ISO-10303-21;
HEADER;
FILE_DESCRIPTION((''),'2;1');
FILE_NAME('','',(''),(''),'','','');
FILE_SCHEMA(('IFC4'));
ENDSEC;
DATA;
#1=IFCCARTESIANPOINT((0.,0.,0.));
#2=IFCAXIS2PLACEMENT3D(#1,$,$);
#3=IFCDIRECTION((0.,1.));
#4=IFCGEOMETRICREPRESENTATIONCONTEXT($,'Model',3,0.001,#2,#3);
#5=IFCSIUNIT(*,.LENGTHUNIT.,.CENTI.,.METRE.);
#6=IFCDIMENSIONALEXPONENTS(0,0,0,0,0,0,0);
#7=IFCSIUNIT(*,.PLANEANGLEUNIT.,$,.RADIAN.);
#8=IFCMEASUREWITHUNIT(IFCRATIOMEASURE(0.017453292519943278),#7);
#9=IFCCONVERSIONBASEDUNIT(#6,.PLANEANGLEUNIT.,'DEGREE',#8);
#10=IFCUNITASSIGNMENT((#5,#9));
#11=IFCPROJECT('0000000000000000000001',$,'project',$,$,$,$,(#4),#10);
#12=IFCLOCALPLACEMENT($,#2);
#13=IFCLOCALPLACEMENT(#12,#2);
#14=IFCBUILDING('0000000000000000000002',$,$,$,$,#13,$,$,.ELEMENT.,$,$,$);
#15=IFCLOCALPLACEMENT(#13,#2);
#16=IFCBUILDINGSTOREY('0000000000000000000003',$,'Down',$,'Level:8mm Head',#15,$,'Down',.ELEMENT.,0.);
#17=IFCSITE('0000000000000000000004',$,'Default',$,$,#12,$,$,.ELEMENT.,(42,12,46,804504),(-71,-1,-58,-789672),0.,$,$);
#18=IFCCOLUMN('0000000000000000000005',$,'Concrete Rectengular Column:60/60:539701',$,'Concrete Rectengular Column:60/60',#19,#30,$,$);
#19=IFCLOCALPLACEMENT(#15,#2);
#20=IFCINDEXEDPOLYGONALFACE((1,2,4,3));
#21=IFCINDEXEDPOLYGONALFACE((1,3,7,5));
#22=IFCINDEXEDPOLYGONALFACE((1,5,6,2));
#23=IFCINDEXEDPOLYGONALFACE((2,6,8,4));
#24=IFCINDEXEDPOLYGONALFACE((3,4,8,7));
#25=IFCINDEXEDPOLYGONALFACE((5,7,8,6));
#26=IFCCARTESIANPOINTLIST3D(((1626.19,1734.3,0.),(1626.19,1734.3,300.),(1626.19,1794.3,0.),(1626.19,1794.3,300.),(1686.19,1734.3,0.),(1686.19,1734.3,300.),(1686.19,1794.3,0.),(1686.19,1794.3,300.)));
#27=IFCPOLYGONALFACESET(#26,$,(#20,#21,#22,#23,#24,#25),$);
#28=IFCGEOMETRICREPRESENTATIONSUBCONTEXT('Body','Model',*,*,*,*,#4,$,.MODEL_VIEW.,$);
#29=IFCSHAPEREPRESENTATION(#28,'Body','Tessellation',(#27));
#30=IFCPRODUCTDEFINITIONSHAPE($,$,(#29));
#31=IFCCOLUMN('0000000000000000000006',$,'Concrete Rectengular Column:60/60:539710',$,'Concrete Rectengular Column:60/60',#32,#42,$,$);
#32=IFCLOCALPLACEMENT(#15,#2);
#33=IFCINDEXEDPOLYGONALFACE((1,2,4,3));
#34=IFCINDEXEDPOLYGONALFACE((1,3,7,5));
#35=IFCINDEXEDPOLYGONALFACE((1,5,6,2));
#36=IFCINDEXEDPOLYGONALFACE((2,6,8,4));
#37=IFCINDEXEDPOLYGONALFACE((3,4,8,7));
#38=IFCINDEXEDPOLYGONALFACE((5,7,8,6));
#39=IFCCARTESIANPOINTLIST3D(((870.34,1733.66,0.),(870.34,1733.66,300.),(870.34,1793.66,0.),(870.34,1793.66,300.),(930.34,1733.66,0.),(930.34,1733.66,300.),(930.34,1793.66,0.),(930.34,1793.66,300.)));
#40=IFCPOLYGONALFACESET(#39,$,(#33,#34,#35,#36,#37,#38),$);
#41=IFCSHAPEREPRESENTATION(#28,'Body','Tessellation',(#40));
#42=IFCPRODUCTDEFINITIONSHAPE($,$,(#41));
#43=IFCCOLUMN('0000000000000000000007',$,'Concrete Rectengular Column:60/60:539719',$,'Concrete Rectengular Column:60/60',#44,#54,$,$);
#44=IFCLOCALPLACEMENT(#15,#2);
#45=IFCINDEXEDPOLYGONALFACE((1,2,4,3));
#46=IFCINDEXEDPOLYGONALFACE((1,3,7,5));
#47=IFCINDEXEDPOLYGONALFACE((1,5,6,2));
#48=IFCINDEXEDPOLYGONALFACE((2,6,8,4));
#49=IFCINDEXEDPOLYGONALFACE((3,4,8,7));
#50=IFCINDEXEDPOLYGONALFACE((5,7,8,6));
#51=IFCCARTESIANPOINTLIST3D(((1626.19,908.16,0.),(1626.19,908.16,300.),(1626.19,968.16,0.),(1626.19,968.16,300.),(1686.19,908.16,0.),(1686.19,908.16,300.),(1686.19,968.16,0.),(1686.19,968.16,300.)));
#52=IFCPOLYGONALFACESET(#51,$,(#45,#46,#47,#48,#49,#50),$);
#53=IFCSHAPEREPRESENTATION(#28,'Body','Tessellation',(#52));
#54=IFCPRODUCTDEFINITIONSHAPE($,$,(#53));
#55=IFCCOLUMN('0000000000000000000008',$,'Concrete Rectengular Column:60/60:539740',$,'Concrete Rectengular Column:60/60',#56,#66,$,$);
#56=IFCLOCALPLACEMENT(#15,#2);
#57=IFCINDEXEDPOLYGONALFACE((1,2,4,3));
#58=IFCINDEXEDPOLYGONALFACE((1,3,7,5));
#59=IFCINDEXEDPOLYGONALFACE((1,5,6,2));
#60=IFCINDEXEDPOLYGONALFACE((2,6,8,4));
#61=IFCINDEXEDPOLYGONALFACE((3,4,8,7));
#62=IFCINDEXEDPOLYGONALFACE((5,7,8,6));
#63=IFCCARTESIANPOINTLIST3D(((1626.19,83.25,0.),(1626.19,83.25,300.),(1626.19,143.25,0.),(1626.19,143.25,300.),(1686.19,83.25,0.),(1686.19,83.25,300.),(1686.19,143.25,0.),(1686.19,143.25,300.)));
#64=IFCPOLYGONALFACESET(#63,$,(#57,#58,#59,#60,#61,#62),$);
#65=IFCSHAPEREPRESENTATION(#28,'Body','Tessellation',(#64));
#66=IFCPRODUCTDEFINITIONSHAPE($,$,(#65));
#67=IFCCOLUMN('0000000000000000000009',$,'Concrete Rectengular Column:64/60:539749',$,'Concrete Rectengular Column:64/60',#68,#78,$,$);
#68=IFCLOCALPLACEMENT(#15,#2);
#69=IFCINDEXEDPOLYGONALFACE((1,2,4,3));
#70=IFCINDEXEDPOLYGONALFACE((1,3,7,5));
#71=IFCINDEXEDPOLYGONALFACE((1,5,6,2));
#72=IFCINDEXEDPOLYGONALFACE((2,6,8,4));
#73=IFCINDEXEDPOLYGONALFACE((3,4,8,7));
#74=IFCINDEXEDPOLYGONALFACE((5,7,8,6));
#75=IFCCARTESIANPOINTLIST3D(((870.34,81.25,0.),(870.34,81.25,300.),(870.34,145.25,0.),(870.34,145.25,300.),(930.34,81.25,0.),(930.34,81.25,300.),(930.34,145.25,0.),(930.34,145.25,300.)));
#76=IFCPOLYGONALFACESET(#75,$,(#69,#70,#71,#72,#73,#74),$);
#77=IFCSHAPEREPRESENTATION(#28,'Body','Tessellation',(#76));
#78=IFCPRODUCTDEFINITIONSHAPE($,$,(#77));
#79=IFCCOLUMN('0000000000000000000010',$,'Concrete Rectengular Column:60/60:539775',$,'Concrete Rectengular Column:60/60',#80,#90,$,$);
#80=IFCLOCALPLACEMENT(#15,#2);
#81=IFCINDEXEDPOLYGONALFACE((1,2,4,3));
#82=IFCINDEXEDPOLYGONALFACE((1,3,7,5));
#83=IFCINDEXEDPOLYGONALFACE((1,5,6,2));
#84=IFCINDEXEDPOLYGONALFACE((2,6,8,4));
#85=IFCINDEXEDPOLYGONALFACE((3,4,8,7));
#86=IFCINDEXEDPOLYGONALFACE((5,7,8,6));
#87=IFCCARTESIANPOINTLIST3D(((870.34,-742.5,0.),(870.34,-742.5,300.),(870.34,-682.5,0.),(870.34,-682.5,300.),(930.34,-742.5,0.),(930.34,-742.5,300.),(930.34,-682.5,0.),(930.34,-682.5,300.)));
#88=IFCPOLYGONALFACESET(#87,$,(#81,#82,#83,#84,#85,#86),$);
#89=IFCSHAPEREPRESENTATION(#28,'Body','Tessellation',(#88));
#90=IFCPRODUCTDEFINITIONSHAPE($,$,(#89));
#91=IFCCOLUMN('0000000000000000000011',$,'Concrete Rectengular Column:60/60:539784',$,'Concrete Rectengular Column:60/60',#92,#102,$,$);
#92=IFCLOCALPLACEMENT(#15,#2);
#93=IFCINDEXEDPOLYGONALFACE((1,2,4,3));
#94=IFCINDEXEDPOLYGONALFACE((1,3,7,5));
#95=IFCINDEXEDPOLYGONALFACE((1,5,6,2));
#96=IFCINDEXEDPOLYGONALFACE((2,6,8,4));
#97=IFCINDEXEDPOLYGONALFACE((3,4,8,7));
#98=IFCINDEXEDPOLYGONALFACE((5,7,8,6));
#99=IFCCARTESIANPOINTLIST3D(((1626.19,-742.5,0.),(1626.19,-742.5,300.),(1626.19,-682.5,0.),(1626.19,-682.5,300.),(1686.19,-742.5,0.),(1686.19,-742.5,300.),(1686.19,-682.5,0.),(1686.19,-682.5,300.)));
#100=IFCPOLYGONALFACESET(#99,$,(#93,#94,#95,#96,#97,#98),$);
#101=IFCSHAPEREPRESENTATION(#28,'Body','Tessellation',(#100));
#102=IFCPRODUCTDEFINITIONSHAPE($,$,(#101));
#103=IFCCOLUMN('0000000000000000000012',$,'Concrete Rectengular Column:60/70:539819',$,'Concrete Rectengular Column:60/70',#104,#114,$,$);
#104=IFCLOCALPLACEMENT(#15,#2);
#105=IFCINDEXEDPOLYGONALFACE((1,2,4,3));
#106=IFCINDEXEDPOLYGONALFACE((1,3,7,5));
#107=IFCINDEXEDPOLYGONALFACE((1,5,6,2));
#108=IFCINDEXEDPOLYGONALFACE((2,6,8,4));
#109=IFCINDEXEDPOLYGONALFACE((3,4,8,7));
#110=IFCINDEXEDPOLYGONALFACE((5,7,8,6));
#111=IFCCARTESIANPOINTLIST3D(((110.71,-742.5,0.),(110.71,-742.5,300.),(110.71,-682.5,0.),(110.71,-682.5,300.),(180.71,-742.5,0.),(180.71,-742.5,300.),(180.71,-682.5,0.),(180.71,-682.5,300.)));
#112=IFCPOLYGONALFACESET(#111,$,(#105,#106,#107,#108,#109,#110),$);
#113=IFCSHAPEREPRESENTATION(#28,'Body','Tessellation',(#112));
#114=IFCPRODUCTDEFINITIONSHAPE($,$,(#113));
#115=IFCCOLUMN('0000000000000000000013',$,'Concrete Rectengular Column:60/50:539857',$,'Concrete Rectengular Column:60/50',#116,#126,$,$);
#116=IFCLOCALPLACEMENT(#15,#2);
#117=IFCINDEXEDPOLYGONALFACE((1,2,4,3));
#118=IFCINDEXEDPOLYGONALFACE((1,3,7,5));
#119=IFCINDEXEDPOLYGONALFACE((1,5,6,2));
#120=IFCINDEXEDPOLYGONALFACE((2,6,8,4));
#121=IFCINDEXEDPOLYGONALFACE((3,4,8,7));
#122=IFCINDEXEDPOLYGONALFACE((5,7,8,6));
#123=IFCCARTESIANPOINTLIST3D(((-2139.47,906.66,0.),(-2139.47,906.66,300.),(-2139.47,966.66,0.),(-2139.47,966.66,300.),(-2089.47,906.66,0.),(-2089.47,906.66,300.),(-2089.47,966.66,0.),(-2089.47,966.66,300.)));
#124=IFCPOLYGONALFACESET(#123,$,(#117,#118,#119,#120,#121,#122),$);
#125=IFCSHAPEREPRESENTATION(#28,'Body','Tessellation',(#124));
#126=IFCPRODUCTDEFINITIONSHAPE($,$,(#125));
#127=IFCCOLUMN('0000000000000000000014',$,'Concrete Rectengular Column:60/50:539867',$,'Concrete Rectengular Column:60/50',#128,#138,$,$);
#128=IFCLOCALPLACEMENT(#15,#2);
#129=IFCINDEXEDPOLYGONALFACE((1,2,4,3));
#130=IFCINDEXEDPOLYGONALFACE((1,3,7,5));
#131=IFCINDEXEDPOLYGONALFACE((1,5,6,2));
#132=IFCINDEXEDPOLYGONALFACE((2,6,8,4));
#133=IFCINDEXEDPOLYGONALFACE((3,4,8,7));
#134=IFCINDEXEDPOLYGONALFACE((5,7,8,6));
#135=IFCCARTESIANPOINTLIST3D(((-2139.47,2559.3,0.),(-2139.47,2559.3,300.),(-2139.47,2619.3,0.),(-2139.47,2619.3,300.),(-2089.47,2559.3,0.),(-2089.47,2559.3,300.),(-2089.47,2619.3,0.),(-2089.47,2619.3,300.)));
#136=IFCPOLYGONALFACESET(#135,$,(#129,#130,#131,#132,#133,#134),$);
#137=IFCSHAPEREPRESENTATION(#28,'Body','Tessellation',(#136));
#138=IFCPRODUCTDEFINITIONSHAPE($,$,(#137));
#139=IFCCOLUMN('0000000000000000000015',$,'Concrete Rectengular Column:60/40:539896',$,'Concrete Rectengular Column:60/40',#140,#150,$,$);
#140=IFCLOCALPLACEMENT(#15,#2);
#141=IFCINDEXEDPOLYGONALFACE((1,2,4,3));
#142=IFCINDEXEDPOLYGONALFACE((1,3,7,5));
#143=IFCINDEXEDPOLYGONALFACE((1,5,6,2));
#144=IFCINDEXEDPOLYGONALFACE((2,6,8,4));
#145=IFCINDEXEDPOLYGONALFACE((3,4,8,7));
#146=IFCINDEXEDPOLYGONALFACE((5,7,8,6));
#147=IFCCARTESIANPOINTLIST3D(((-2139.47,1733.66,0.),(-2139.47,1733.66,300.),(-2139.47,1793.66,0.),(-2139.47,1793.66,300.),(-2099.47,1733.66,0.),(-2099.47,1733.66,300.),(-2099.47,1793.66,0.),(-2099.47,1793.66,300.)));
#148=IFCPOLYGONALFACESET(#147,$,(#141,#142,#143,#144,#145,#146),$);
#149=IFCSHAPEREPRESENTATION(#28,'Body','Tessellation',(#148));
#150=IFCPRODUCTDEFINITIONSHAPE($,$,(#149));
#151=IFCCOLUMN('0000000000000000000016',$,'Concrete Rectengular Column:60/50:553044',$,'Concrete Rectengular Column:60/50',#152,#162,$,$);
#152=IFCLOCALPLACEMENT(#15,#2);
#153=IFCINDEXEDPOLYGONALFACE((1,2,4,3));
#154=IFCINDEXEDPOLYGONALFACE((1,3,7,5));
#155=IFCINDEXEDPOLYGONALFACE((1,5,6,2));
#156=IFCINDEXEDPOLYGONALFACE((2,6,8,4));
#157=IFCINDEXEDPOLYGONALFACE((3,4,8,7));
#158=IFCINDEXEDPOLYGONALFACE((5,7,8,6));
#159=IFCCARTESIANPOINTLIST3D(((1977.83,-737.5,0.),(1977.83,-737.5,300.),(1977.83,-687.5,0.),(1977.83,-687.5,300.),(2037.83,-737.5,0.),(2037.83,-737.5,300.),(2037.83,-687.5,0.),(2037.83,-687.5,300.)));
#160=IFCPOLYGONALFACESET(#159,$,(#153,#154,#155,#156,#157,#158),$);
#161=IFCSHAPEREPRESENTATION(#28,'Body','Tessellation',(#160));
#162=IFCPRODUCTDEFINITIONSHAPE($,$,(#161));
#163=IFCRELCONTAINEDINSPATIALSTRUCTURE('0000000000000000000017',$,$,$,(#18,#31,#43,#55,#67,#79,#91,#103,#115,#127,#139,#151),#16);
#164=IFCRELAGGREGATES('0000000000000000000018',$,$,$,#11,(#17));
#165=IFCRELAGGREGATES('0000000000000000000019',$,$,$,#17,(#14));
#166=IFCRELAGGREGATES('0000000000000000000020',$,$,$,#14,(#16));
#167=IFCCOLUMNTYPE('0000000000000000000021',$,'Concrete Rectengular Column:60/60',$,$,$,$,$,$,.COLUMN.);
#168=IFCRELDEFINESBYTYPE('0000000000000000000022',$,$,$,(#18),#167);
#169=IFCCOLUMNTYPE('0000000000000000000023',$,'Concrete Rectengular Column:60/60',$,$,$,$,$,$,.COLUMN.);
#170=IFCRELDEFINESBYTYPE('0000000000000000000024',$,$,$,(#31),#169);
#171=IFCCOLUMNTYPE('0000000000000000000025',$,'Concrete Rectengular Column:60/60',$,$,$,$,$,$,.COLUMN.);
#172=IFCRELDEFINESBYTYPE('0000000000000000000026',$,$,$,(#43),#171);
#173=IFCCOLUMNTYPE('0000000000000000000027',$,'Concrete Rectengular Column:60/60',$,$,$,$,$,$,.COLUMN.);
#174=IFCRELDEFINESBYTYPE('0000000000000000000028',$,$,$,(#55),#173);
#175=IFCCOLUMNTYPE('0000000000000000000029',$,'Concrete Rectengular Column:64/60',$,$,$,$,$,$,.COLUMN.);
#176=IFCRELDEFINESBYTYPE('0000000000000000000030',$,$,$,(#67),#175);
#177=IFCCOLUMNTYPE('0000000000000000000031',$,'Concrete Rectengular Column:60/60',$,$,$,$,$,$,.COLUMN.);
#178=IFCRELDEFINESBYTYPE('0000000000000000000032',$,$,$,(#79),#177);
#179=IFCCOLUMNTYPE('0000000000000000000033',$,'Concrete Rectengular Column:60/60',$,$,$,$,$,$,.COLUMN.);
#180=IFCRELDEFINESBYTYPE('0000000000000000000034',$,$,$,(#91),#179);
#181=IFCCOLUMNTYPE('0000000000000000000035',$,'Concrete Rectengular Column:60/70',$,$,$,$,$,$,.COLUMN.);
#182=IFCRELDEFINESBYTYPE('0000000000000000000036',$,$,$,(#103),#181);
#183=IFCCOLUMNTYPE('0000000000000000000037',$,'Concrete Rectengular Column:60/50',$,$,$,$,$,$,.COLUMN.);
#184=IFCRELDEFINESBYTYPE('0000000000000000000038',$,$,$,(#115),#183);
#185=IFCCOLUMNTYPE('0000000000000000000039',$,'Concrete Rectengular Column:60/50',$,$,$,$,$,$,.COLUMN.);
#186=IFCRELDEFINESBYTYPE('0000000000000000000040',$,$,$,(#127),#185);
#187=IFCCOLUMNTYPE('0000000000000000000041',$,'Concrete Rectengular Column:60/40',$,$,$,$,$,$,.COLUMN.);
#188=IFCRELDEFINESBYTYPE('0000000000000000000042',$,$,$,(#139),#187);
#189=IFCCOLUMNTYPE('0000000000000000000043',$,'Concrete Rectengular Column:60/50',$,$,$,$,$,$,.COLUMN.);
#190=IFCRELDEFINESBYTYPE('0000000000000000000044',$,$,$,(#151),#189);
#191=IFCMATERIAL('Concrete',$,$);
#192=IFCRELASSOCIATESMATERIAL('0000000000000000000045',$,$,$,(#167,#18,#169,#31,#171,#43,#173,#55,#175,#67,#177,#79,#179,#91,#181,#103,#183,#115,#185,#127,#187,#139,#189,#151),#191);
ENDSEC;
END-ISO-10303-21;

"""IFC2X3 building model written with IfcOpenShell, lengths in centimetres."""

from ifc_helpers import new_model, entity, si_unit, converted_unit, direction, frame, frame_2d, origin, origin_2d_with_axis, place, context, subcontext, project, spatial, rectangle, extrude, source, transform, mapped, material, type_object, type_shapes, element, save


model = new_model("IFC2X3")

# Units and contexts
model_context = context("Model", 3, precision=0.001, world=origin(), true_north=direction((0.0, 1.0)))
body_context = subcontext(model_context, "Body", "Model", "MODEL_VIEW")
ifc_project = project(units=[si_unit("LENGTHUNIT", "METRE", prefix="CENTI"), converted_unit("PLANEANGLEUNIT", "DEGREE", entity("IfcRatioMeasure", 0.017453292519943278), si_unit("PLANEANGLEUNIT", "RADIAN"), dimensions=[0, 0, 0, 0, 0, 0, 0])], contexts=[model_context])

# Site, building, storey
site_placement = place(None, origin())
site = spatial("IfcSite", under=ifc_project, at=site_placement, Name="Default", CompositionType="ELEMENT", RefLatitude=(42, 12, 46, 804504), RefLongitude=(-71, -1, -58, -789672), RefElevation=0.0)
building_placement = place(site_placement, origin())
building = spatial("IfcBuilding", under=site, at=building_placement, CompositionType="ELEMENT")
storey_placement = place(building_placement, origin())
storey = spatial("IfcBuildingStorey", under=building, at=storey_placement, Name="Down", ObjectType="Level:8mm Head", LongName="Down", CompositionType="ELEMENT", Elevation=0.0)

# Columns
ifc_material = material(Name="Concrete")
column_type_1 = type_object("IfcColumnType", Name="Concrete Rectengular Column:60/60", PredefinedType="COLUMN", material=ifc_material)
shared_shape_1 = source(origin(), body_context, "Body", "SweptSolid", [
    extrude(rectangle(XDim=60.0, YDim=60.0, at=frame_2d((0.0, 0.0), x_axis=(1.0, 0.0))), frame((1656.19, 1764.3, 0.0), z_axis=(0.0, 0.0, 1.0), x_axis=(0.0, -1.0, 0.0)), (0.0, 0.0, 1.0), 300.0),
])
type_shapes(column_type_1, [shared_shape_1])
column_1_placement = place(storey_placement, origin())
element("IfcColumn", 1, at=column_1_placement, inside=storey, type_object=column_type_1, material=ifc_material, Name="Concrete Rectengular Column:60/60:539701", ObjectType="Concrete Rectengular Column:60/60", context=body_context, shape_type="MappedRepresentation", body=[
    mapped(shared_shape_1, transform((0.0, 0.0, 0.0), scale=1.0)),
])
column_type_2 = type_object("IfcColumnType", Name="Concrete Rectengular Column:60/60", PredefinedType="COLUMN", material=ifc_material)
shared_shape_2 = source(origin(), body_context, "Body", "SweptSolid", [
    extrude(rectangle(XDim=60.0, YDim=60.0, at=frame_2d((0.0, 0.0), x_axis=(1.0, 0.0))), frame((900.34, 1763.66, 0.0), z_axis=(0.0, 0.0, 1.0), x_axis=(0.0, -1.0, 0.0)), (0.0, 0.0, 1.0), 300.0),
])
type_shapes(column_type_2, [shared_shape_2])
column_2_placement = place(storey_placement, origin())
element("IfcColumn", 2, at=column_2_placement, inside=storey, type_object=column_type_2, material=ifc_material, Name="Concrete Rectengular Column:60/60:539710", ObjectType="Concrete Rectengular Column:60/60", context=body_context, shape_type="MappedRepresentation", body=[
    mapped(shared_shape_2, transform((0.0, 0.0, 0.0), scale=1.0)),
])
column_type_3 = type_object("IfcColumnType", Name="Concrete Rectengular Column:60/60", PredefinedType="COLUMN", material=ifc_material)
shared_shape_3 = source(origin(), body_context, "Body", "SweptSolid", [
    extrude(rectangle(XDim=60.0, YDim=60.0, at=frame_2d((0.0, 0.0), x_axis=(1.0, 0.0))), frame((1656.19, 938.16, 0.0), z_axis=(0.0, 0.0, 1.0), x_axis=(0.0, -1.0, 0.0)), (0.0, 0.0, 1.0), 300.0),
])
type_shapes(column_type_3, [shared_shape_3])
column_3_placement = place(storey_placement, origin())
element("IfcColumn", 3, at=column_3_placement, inside=storey, type_object=column_type_3, material=ifc_material, Name="Concrete Rectengular Column:60/60:539719", ObjectType="Concrete Rectengular Column:60/60", context=body_context, shape_type="MappedRepresentation", body=[
    mapped(shared_shape_3, transform((0.0, 0.0, 0.0), scale=1.0)),
])
column_type_4 = type_object("IfcColumnType", Name="Concrete Rectengular Column:60/60", PredefinedType="COLUMN", material=ifc_material)
shared_shape_4 = source(origin(), body_context, "Body", "SweptSolid", [
    extrude(rectangle(XDim=60.0, YDim=60.0, at=frame_2d((0.0, 0.0), x_axis=(1.0, 0.0))), frame((1656.19, 113.25, 0.0), z_axis=(0.0, 0.0, 1.0), x_axis=(0.0, -1.0, 0.0)), (0.0, 0.0, 1.0), 300.0),
])
type_shapes(column_type_4, [shared_shape_4])
column_4_placement = place(storey_placement, origin())
element("IfcColumn", 4, at=column_4_placement, inside=storey, type_object=column_type_4, material=ifc_material, Name="Concrete Rectengular Column:60/60:539740", ObjectType="Concrete Rectengular Column:60/60", context=body_context, shape_type="MappedRepresentation", body=[
    mapped(shared_shape_4, transform((0.0, 0.0, 0.0), scale=1.0)),
])
column_type_5 = type_object("IfcColumnType", Name="Concrete Rectengular Column:64/60", PredefinedType="COLUMN", material=ifc_material)
shared_shape_5 = source(origin(), body_context, "Body", "SweptSolid", [
    extrude(rectangle(XDim=64.0, YDim=60.0, at=origin_2d_with_axis()), frame((900.34, 113.25, 0.0), z_axis=(0.0, 0.0, 1.0), x_axis=(0.0, -1.0, 0.0)), (0.0, 0.0, 1.0), 300.0),
])
type_shapes(column_type_5, [shared_shape_5])
column_5_placement = place(storey_placement, origin())
element("IfcColumn", 5, at=column_5_placement, inside=storey, type_object=column_type_5, material=ifc_material, Name="Concrete Rectengular Column:64/60:539749", ObjectType="Concrete Rectengular Column:64/60", context=body_context, shape_type="MappedRepresentation", body=[
    mapped(shared_shape_5, transform((0.0, 0.0, 0.0), scale=1.0)),
])
column_type_6 = type_object("IfcColumnType", Name="Concrete Rectengular Column:60/60", PredefinedType="COLUMN", material=ifc_material)
shared_shape_6 = source(origin(), body_context, "Body", "SweptSolid", [
    extrude(rectangle(XDim=60.0, YDim=60.0, at=origin_2d_with_axis()), frame((900.34, -712.5, 0.0), z_axis=(0.0, 0.0, 1.0), x_axis=(0.0, -1.0, 0.0)), (0.0, 0.0, 1.0), 300.0),
])
type_shapes(column_type_6, [shared_shape_6])
column_6_placement = place(storey_placement, origin())
element("IfcColumn", 6, at=column_6_placement, inside=storey, type_object=column_type_6, material=ifc_material, Name="Concrete Rectengular Column:60/60:539775", ObjectType="Concrete Rectengular Column:60/60", context=body_context, shape_type="MappedRepresentation", body=[
    mapped(shared_shape_6, transform((0.0, 0.0, 0.0), scale=1.0)),
])
column_type_7 = type_object("IfcColumnType", Name="Concrete Rectengular Column:60/60", PredefinedType="COLUMN", material=ifc_material)
shared_shape_7 = source(origin(), body_context, "Body", "SweptSolid", [
    extrude(rectangle(XDim=60.0, YDim=60.0, at=frame_2d((0.0, 0.0), x_axis=(1.0, 0.0))), frame((1656.19, -712.5, 0.0), z_axis=(0.0, 0.0, 1.0), x_axis=(0.0, -1.0, 0.0)), (0.0, 0.0, 1.0), 300.0),
])
type_shapes(column_type_7, [shared_shape_7])
column_7_placement = place(storey_placement, origin())
element("IfcColumn", 7, at=column_7_placement, inside=storey, type_object=column_type_7, material=ifc_material, Name="Concrete Rectengular Column:60/60:539784", ObjectType="Concrete Rectengular Column:60/60", context=body_context, shape_type="MappedRepresentation", body=[
    mapped(shared_shape_7, transform((0.0, 0.0, 0.0), scale=1.0)),
])
column_type_8 = type_object("IfcColumnType", Name="Concrete Rectengular Column:60/70", PredefinedType="COLUMN", material=ifc_material)
shared_shape_8 = source(origin(), body_context, "Body", "SweptSolid", [
    extrude(rectangle(XDim=60.0, YDim=70.0, at=frame_2d((0.0, 0.0), x_axis=(1.0, 0.0))), frame((145.71, -712.5, 0.0), z_axis=(0.0, 0.0, 1.0), x_axis=(0.0, -1.0, 0.0)), (0.0, 0.0, 1.0), 300.0),
])
type_shapes(column_type_8, [shared_shape_8])
column_8_placement = place(storey_placement, origin())
element("IfcColumn", 8, at=column_8_placement, inside=storey, type_object=column_type_8, material=ifc_material, Name="Concrete Rectengular Column:60/70:539819", ObjectType="Concrete Rectengular Column:60/70", context=body_context, shape_type="MappedRepresentation", body=[
    mapped(shared_shape_8, transform((0.0, 0.0, 0.0), scale=1.0)),
])
column_type_9 = type_object("IfcColumnType", Name="Concrete Rectengular Column:60/50", PredefinedType="COLUMN", material=ifc_material)
shared_shape_9 = source(origin(), body_context, "Body", "SweptSolid", [
    extrude(rectangle(XDim=60.0, YDim=50.0, at=origin_2d_with_axis()), frame((-2114.47, 936.66, 0.0), z_axis=(0.0, 0.0, 1.0), x_axis=(0.0, -1.0, 0.0)), (0.0, 0.0, 1.0), 300.0),
])
type_shapes(column_type_9, [shared_shape_9])
column_9_placement = place(storey_placement, origin())
element("IfcColumn", 9, at=column_9_placement, inside=storey, type_object=column_type_9, material=ifc_material, Name="Concrete Rectengular Column:60/50:539857", ObjectType="Concrete Rectengular Column:60/50", context=body_context, shape_type="MappedRepresentation", body=[
    mapped(shared_shape_9, transform((0.0, 0.0, 0.0), scale=1.0)),
])
column_type_10 = type_object("IfcColumnType", Name="Concrete Rectengular Column:60/50", PredefinedType="COLUMN", material=ifc_material)
shared_shape_10 = source(origin(), body_context, "Body", "SweptSolid", [
    extrude(rectangle(XDim=60.0, YDim=50.0, at=origin_2d_with_axis()), frame((-2114.47, 2589.3, 0.0), z_axis=(0.0, 0.0, 1.0), x_axis=(0.0, -1.0, 0.0)), (0.0, 0.0, 1.0), 300.0),
])
type_shapes(column_type_10, [shared_shape_10])
column_10_placement = place(storey_placement, origin())
element("IfcColumn", 10, at=column_10_placement, inside=storey, type_object=column_type_10, material=ifc_material, Name="Concrete Rectengular Column:60/50:539867", ObjectType="Concrete Rectengular Column:60/50", context=body_context, shape_type="MappedRepresentation", body=[
    mapped(shared_shape_10, transform((0.0, 0.0, 0.0), scale=1.0)),
])
column_type_11 = type_object("IfcColumnType", Name="Concrete Rectengular Column:60/40", PredefinedType="COLUMN", material=ifc_material)
shared_shape_11 = source(origin(), body_context, "Body", "SweptSolid", [
    extrude(rectangle(XDim=60.0, YDim=40.0, at=frame_2d((0.0, 0.0), x_axis=(1.0, 0.0))), frame((-2119.47, 1763.66, 0.0), z_axis=(0.0, 0.0, 1.0), x_axis=(0.0, -1.0, 0.0)), (0.0, 0.0, 1.0), 300.0),
])
type_shapes(column_type_11, [shared_shape_11])
column_11_placement = place(storey_placement, origin())
element("IfcColumn", 11, at=column_11_placement, inside=storey, type_object=column_type_11, material=ifc_material, Name="Concrete Rectengular Column:60/40:539896", ObjectType="Concrete Rectengular Column:60/40", context=body_context, shape_type="MappedRepresentation", body=[
    mapped(shared_shape_11, transform((0.0, 0.0, 0.0), scale=1.0)),
])
column_type_12 = type_object("IfcColumnType", Name="Concrete Rectengular Column:60/50", PredefinedType="COLUMN", material=ifc_material)
shared_shape_12 = source(origin(), body_context, "Body", "SweptSolid", [
    extrude(rectangle(XDim=50.0, YDim=60.0, at=origin_2d_with_axis()), frame((2007.83, -712.5, 0.0), z_axis=(0.0, 0.0, 1.0), x_axis=(0.0, -1.0, 0.0)), (0.0, 0.0, 1.0), 300.0),
])
type_shapes(column_type_12, [shared_shape_12])
column_12_placement = place(storey_placement, origin())
element("IfcColumn", 12, at=column_12_placement, inside=storey, type_object=column_type_12, material=ifc_material, Name="Concrete Rectengular Column:60/50:553044", ObjectType="Concrete Rectengular Column:60/50", context=body_context, shape_type="MappedRepresentation", body=[
    mapped(shared_shape_12, transform((0.0, 0.0, 0.0), scale=1.0)),
])

save(model, "model.ifc")
